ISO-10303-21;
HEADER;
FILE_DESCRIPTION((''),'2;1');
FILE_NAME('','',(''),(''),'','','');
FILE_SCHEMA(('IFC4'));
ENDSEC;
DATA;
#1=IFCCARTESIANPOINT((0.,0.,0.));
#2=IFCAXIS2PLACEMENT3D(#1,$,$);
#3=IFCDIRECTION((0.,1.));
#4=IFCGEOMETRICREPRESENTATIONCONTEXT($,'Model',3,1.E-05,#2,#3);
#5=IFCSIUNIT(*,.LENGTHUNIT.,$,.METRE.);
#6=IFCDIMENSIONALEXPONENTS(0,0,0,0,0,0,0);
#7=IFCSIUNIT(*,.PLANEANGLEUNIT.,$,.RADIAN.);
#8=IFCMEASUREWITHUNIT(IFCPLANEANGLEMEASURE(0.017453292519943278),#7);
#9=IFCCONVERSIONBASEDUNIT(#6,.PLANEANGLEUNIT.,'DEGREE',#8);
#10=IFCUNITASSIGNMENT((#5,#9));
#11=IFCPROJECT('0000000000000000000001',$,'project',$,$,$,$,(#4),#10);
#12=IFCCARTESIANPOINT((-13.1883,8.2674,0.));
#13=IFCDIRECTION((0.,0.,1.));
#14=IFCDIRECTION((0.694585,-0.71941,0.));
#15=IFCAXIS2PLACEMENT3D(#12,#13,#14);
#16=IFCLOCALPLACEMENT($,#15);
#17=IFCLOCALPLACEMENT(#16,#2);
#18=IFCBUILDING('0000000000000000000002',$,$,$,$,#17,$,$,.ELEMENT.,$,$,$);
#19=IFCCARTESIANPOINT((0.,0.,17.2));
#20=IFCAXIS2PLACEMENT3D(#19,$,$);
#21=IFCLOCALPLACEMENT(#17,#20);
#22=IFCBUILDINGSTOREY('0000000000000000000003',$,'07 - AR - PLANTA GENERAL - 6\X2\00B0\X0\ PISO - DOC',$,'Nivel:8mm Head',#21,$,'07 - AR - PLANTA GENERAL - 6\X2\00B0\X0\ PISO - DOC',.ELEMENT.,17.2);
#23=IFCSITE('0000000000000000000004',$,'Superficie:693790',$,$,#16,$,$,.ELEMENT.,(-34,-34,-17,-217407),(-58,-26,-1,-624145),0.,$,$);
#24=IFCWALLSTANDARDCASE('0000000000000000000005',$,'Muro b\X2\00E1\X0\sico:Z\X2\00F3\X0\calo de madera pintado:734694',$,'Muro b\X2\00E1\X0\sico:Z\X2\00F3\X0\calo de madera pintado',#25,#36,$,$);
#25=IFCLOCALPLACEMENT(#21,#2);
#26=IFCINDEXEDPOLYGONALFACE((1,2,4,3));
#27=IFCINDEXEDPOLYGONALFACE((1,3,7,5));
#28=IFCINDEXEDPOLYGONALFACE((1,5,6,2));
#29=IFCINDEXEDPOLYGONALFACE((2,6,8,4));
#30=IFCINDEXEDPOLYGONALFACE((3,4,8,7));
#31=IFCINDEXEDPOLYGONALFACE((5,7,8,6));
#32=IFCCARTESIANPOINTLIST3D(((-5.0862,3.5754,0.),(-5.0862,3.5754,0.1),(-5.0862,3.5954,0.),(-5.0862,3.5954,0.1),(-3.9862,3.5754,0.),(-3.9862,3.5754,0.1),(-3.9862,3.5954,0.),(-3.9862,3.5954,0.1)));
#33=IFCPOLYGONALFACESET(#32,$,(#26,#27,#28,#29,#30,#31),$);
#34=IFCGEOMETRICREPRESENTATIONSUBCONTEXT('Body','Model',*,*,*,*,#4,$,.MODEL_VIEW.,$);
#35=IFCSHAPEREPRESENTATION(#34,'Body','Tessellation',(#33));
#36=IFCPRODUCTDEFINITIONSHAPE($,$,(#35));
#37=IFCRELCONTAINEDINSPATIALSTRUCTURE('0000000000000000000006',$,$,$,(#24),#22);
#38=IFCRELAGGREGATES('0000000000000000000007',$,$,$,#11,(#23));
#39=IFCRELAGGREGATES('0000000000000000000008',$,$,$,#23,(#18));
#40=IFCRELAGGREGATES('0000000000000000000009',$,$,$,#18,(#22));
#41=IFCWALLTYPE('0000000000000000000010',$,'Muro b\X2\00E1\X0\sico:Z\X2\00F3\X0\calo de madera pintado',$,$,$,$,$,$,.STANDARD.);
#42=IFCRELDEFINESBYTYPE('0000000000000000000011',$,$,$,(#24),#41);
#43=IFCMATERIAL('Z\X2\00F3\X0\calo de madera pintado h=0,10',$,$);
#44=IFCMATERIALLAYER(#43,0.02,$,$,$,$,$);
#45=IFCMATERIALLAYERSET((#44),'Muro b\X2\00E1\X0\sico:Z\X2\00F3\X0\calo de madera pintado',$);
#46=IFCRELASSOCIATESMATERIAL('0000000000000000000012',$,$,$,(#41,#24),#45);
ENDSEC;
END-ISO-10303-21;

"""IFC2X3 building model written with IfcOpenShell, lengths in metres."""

from ifc_helpers import new_model, entity, si_unit, converted_unit, direction, frame, frame_2d, origin, place, context, subcontext, project, spatial, rectangle, extrude, material, layer, layer_set, layer_usage, type_object, element, save


model = new_model("IFC2X3")

# Units and contexts
model_context = context("Model", 3, precision=1e-05, world=origin(), true_north=direction((0.0, 1.0)))
body_context = subcontext(model_context, "Body", "Model", "MODEL_VIEW")
ifc_project = project(units=[si_unit("LENGTHUNIT", "METRE"), converted_unit("PLANEANGLEUNIT", "DEGREE", entity("IfcPlaneAngleMeasure", 0.017453292519943278), si_unit("PLANEANGLEUNIT", "RADIAN"), dimensions=[0, 0, 0, 0, 0, 0, 0])], contexts=[model_context])

# Site, building, storey
site_placement = place(None, frame((-13.1883, 8.2674, 0.0), z_axis=(0.0, 0.0, 1.0), x_axis=(0.694585, -0.71941, 0.0)))
site = spatial("IfcSite", under=ifc_project, at=site_placement, Name="Superficie:693790", CompositionType="ELEMENT", RefLatitude=(-34, -34, -17, -217407), RefLongitude=(-58, -26, -1, -624145), RefElevation=0.0)
building_placement = place(site_placement, origin())
building = spatial("IfcBuilding", under=site, at=building_placement, CompositionType="ELEMENT")
storey_placement = place(building_placement, frame((0.0, 0.0, 17.2)))
storey = spatial("IfcBuildingStorey", under=building, at=storey_placement, Name="07 - AR - PLANTA GENERAL - 6° PISO - DOC", ObjectType="Nivel:8mm Head", LongName="07 - AR - PLANTA GENERAL - 6° PISO - DOC", CompositionType="ELEMENT", Elevation=17.2)

# Shared definitions
ifc_material_1 = material(Name="Zócalo de madera pintado h=0,10")
ifc_layer_1 = layer(ifc_material_1, 0.02)
ifc_layer_set_1 = layer_set([ifc_layer_1], Name="Muro básico:Zócalo de madera pintado")
wall_type_1 = type_object("IfcWallType", Name="Muro básico:Zócalo de madera pintado", PredefinedType="STANDARD", material=ifc_layer_set_1)

# Wall
ifc_layer_usage_1 = layer_usage(ifc_layer_set_1, "AXIS2", "NEGATIVE", 0.01)
wall_1_placement = place(storey_placement, frame((-3.9862, 3.5854, 0.0), z_axis=(0.0, 0.0, 1.0), x_axis=(-1.0, 0.0, 0.0)))
element("IfcWallStandardCase", 1, at=wall_1_placement, inside=storey, type_object=wall_type_1, material=ifc_layer_usage_1, Name="Muro básico:Zócalo de madera pintado:734694", ObjectType="Muro básico:Zócalo de madera pintado", context=body_context, shape_type="SweptSolid", body=[
    extrude(rectangle(XDim=1.1, YDim=0.02, at=frame_2d((0.55, 0.0), x_axis=(-1.0, 0.0))), origin(), (0.0, 0.0, 1.0), 0.1),
])

save(model, "model.ifc")
